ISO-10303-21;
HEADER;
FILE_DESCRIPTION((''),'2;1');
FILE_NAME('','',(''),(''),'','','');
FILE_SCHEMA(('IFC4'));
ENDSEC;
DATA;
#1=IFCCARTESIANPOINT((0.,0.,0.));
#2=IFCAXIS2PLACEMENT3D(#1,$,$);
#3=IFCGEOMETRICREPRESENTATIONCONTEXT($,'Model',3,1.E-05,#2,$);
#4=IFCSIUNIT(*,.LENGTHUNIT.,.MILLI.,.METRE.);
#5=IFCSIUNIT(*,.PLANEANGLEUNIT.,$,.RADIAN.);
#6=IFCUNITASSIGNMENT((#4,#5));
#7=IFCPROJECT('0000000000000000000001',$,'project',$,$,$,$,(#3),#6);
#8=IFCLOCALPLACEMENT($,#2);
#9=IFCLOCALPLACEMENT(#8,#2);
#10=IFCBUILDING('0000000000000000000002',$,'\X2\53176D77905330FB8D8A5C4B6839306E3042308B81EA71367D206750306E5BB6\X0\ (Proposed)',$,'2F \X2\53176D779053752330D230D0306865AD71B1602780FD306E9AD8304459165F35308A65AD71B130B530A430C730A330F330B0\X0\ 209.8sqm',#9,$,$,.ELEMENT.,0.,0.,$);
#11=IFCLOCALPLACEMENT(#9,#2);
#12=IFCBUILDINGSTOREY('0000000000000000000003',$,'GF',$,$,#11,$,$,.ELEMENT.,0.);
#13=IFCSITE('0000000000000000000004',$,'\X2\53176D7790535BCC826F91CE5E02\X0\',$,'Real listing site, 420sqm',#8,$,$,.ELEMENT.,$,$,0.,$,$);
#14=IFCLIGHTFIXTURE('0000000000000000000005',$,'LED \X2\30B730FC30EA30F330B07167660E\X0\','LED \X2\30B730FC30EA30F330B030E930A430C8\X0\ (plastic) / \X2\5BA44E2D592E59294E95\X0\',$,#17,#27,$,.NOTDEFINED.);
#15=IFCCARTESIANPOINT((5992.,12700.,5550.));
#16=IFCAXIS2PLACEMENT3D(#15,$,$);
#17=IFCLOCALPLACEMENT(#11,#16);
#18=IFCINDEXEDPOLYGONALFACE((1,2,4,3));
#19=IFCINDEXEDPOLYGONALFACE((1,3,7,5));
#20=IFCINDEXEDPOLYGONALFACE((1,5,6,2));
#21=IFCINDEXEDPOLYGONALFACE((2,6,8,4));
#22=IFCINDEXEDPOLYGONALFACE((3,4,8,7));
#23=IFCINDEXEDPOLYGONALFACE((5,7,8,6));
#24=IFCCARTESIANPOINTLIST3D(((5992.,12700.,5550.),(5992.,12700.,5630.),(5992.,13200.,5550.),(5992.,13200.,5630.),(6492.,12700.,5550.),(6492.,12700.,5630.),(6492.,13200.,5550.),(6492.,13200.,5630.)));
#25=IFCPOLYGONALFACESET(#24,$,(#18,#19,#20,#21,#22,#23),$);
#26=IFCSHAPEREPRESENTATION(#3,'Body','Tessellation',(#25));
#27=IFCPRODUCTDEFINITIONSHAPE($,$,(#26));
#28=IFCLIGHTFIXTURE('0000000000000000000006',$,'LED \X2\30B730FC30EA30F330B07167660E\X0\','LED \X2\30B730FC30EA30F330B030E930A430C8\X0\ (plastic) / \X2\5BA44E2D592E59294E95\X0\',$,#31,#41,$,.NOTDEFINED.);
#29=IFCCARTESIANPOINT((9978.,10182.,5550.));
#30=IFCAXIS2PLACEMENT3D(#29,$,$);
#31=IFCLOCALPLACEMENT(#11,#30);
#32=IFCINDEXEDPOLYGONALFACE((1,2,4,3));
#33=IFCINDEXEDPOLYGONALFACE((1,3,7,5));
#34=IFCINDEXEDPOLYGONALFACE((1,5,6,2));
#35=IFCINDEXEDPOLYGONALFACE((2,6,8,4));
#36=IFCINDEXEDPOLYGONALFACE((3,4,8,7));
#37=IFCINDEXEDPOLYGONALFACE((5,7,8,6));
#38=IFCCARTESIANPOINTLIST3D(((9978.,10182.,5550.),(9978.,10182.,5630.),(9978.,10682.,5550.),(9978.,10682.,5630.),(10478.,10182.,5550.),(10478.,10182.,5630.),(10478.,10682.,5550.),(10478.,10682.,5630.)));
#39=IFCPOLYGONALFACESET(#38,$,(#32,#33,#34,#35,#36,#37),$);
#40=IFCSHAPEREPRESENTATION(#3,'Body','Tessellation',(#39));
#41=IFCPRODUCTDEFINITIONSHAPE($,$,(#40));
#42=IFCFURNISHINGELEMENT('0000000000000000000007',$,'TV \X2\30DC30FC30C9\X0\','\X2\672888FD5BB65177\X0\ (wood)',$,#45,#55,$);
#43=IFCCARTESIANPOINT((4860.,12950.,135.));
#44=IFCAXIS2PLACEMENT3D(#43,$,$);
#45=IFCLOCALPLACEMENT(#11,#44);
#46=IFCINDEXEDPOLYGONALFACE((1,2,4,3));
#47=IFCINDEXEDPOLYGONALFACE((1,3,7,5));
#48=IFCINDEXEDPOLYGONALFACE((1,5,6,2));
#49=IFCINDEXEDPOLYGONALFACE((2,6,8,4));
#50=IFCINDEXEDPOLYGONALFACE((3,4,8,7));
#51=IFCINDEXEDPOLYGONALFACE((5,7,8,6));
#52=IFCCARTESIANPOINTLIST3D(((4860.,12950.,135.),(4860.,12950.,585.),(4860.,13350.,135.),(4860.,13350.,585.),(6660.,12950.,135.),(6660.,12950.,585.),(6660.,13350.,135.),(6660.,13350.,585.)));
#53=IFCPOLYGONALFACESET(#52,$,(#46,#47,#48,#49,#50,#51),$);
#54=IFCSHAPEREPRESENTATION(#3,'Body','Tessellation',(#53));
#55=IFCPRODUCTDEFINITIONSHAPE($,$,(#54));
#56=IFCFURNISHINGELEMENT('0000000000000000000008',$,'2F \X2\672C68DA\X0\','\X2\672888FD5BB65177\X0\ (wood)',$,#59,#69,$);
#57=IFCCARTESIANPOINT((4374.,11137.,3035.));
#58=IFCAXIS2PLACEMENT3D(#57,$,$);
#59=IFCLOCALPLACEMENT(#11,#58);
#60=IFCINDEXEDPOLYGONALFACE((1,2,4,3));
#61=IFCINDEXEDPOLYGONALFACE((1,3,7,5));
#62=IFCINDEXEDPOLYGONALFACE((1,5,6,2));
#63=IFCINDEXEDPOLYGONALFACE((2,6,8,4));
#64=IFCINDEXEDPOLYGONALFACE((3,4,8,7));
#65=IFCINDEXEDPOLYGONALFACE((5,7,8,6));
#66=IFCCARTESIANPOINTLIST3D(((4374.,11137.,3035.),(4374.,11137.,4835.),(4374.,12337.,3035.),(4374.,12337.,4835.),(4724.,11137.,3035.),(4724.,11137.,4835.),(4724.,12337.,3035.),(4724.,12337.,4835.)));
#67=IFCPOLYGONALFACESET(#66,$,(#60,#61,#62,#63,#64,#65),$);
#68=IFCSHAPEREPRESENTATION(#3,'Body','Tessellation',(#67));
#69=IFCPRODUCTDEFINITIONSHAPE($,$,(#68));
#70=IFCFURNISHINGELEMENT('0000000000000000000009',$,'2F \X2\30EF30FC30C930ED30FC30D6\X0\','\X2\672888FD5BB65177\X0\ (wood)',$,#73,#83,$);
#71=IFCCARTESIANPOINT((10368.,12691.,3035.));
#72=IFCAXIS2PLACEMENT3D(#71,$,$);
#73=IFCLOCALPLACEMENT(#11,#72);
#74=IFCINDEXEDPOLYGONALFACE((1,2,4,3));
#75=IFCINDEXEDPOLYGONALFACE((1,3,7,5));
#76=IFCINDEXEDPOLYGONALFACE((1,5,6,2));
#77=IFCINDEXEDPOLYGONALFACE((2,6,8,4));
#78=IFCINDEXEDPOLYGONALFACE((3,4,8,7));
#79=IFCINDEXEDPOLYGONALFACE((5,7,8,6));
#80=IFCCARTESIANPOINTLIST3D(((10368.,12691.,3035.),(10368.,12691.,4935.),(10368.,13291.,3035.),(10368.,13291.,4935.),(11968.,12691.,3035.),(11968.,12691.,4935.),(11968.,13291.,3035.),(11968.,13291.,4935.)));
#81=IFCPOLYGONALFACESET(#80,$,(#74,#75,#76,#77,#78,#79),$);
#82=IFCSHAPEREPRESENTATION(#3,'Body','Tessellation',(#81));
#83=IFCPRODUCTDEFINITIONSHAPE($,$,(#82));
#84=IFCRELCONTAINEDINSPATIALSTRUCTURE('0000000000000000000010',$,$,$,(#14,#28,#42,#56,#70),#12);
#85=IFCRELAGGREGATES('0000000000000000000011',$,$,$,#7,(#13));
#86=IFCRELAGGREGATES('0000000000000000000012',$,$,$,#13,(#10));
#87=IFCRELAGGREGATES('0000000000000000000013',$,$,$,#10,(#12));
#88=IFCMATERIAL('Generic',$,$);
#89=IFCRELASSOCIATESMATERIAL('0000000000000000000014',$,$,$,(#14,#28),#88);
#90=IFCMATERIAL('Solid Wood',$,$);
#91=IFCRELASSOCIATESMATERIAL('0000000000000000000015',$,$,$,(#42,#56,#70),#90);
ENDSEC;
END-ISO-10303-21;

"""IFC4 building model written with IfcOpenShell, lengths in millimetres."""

from ifc_helpers import new_model, si_unit, frame, frame_2d, origin, place, context, project, spatial, rectangle, extrude, material, element, save


model = new_model("IFC4")

# Units and contexts
model_context = context("Model", 3, precision=1e-05, world=origin())
ifc_project = project(units=[si_unit("LENGTHUNIT", "METRE", prefix="MILLI"), si_unit("PLANEANGLEUNIT", "RADIAN")], contexts=[model_context])

# Site, building, storey
site_placement = place(None, origin())
site = spatial("IfcSite", under=ifc_project, at=site_placement, Name="北海道富良野市", ObjectType="Real listing site, 420sqm", CompositionType="ELEMENT", RefElevation=0.0)
building_placement = place(site_placement, origin())
building = spatial("IfcBuilding", under=site, at=building_placement, Name="北海道・越屋根のある自然素材の家 (Proposed)", ObjectType="2F 北海道産ヒバと断熱性能の高い外張り断熱サイディング 209.8sqm", CompositionType="ELEMENT", ElevationOfRefHeight=0.0, ElevationOfTerrain=0.0)
storey_placement = place(building_placement, origin())
storey = spatial("IfcBuildingStorey", under=building, at=storey_placement, Name="GF", CompositionType="ELEMENT", Elevation=0.0)

# Shared definitions
ifc_material_1 = material(Name="Solid Wood")

# Shared definitions
ifc_material_2 = material(Name="Generic")

# Light fixtures
light_fixture_1_placement = place(storey_placement, frame((5992.0, 12700.0, 5550.0)))
element("IfcLightFixture", 1, at=light_fixture_1_placement, inside=storey, material=ifc_material_2, Name="LED シーリング照明", Description="LED シーリングライト (plastic) / 室中央天井", PredefinedType="NOTDEFINED", context=model_context, shape_type="SweptSolid", body=[
    extrude(rectangle(XDim=500.0, YDim=500.0, at=frame_2d((250.0, 250.0))), frame((5992.0, 12700.0, 5550.0)), (0.0, 0.0, 1.0), 80.0),
])
light_fixture_2_placement = place(storey_placement, frame((9978.0, 10182.0, 5550.0)))
element("IfcLightFixture", 2, at=light_fixture_2_placement, inside=storey, material=ifc_material_2, Name="LED シーリング照明", Description="LED シーリングライト (plastic) / 室中央天井", PredefinedType="NOTDEFINED", context=model_context, shape_type="SweptSolid", body=[
    extrude(rectangle(XDim=500.0, YDim=500.0, at=frame_2d((250.0, 250.0))), frame((9978.0, 10182.0, 5550.0)), (0.0, 0.0, 1.0), 80.0),
])

# Furnishing elements
furnishing_1_placement = place(storey_placement, frame((4860.0, 12950.0, 135.0)))
element("IfcFurnishingElement", 3, at=furnishing_1_placement, inside=storey, material=ifc_material_1, Name="TV ボード", Description="木製家具 (wood)", context=model_context, shape_type="SweptSolid", body=[
    extrude(rectangle(XDim=1800.0, YDim=400.0, at=frame_2d((900.0, 200.0))), frame((4860.0, 12950.0, 135.0)), (0.0, 0.0, 1.0), 450.0),
])
furnishing_2_placement = place(storey_placement, frame((4374.0, 11137.0, 3035.0)))
element("IfcFurnishingElement", 4, at=furnishing_2_placement, inside=storey, material=ifc_material_1, Name="2F 本棚", Description="木製家具 (wood)", context=model_context, shape_type="SweptSolid", body=[
    extrude(rectangle(XDim=350.0, YDim=1200.0, at=frame_2d((175.0, 600.0))), frame((4374.0, 11137.0, 3035.0)), (0.0, 0.0, 1.0), 1800.0),
])
furnishing_3_placement = place(storey_placement, frame((10368.0, 12691.0, 3035.0)))
element("IfcFurnishingElement", 5, at=furnishing_3_placement, inside=storey, material=ifc_material_1, Name="2F ワードローブ", Description="木製家具 (wood)", context=model_context, shape_type="SweptSolid", body=[
    extrude(rectangle(XDim=1600.0, YDim=600.0, at=frame_2d((800.0, 300.0))), frame((10368.0, 12691.0, 3035.0)), (0.0, 0.0, 1.0), 1900.0),
])

save(model, "model.ifc")
